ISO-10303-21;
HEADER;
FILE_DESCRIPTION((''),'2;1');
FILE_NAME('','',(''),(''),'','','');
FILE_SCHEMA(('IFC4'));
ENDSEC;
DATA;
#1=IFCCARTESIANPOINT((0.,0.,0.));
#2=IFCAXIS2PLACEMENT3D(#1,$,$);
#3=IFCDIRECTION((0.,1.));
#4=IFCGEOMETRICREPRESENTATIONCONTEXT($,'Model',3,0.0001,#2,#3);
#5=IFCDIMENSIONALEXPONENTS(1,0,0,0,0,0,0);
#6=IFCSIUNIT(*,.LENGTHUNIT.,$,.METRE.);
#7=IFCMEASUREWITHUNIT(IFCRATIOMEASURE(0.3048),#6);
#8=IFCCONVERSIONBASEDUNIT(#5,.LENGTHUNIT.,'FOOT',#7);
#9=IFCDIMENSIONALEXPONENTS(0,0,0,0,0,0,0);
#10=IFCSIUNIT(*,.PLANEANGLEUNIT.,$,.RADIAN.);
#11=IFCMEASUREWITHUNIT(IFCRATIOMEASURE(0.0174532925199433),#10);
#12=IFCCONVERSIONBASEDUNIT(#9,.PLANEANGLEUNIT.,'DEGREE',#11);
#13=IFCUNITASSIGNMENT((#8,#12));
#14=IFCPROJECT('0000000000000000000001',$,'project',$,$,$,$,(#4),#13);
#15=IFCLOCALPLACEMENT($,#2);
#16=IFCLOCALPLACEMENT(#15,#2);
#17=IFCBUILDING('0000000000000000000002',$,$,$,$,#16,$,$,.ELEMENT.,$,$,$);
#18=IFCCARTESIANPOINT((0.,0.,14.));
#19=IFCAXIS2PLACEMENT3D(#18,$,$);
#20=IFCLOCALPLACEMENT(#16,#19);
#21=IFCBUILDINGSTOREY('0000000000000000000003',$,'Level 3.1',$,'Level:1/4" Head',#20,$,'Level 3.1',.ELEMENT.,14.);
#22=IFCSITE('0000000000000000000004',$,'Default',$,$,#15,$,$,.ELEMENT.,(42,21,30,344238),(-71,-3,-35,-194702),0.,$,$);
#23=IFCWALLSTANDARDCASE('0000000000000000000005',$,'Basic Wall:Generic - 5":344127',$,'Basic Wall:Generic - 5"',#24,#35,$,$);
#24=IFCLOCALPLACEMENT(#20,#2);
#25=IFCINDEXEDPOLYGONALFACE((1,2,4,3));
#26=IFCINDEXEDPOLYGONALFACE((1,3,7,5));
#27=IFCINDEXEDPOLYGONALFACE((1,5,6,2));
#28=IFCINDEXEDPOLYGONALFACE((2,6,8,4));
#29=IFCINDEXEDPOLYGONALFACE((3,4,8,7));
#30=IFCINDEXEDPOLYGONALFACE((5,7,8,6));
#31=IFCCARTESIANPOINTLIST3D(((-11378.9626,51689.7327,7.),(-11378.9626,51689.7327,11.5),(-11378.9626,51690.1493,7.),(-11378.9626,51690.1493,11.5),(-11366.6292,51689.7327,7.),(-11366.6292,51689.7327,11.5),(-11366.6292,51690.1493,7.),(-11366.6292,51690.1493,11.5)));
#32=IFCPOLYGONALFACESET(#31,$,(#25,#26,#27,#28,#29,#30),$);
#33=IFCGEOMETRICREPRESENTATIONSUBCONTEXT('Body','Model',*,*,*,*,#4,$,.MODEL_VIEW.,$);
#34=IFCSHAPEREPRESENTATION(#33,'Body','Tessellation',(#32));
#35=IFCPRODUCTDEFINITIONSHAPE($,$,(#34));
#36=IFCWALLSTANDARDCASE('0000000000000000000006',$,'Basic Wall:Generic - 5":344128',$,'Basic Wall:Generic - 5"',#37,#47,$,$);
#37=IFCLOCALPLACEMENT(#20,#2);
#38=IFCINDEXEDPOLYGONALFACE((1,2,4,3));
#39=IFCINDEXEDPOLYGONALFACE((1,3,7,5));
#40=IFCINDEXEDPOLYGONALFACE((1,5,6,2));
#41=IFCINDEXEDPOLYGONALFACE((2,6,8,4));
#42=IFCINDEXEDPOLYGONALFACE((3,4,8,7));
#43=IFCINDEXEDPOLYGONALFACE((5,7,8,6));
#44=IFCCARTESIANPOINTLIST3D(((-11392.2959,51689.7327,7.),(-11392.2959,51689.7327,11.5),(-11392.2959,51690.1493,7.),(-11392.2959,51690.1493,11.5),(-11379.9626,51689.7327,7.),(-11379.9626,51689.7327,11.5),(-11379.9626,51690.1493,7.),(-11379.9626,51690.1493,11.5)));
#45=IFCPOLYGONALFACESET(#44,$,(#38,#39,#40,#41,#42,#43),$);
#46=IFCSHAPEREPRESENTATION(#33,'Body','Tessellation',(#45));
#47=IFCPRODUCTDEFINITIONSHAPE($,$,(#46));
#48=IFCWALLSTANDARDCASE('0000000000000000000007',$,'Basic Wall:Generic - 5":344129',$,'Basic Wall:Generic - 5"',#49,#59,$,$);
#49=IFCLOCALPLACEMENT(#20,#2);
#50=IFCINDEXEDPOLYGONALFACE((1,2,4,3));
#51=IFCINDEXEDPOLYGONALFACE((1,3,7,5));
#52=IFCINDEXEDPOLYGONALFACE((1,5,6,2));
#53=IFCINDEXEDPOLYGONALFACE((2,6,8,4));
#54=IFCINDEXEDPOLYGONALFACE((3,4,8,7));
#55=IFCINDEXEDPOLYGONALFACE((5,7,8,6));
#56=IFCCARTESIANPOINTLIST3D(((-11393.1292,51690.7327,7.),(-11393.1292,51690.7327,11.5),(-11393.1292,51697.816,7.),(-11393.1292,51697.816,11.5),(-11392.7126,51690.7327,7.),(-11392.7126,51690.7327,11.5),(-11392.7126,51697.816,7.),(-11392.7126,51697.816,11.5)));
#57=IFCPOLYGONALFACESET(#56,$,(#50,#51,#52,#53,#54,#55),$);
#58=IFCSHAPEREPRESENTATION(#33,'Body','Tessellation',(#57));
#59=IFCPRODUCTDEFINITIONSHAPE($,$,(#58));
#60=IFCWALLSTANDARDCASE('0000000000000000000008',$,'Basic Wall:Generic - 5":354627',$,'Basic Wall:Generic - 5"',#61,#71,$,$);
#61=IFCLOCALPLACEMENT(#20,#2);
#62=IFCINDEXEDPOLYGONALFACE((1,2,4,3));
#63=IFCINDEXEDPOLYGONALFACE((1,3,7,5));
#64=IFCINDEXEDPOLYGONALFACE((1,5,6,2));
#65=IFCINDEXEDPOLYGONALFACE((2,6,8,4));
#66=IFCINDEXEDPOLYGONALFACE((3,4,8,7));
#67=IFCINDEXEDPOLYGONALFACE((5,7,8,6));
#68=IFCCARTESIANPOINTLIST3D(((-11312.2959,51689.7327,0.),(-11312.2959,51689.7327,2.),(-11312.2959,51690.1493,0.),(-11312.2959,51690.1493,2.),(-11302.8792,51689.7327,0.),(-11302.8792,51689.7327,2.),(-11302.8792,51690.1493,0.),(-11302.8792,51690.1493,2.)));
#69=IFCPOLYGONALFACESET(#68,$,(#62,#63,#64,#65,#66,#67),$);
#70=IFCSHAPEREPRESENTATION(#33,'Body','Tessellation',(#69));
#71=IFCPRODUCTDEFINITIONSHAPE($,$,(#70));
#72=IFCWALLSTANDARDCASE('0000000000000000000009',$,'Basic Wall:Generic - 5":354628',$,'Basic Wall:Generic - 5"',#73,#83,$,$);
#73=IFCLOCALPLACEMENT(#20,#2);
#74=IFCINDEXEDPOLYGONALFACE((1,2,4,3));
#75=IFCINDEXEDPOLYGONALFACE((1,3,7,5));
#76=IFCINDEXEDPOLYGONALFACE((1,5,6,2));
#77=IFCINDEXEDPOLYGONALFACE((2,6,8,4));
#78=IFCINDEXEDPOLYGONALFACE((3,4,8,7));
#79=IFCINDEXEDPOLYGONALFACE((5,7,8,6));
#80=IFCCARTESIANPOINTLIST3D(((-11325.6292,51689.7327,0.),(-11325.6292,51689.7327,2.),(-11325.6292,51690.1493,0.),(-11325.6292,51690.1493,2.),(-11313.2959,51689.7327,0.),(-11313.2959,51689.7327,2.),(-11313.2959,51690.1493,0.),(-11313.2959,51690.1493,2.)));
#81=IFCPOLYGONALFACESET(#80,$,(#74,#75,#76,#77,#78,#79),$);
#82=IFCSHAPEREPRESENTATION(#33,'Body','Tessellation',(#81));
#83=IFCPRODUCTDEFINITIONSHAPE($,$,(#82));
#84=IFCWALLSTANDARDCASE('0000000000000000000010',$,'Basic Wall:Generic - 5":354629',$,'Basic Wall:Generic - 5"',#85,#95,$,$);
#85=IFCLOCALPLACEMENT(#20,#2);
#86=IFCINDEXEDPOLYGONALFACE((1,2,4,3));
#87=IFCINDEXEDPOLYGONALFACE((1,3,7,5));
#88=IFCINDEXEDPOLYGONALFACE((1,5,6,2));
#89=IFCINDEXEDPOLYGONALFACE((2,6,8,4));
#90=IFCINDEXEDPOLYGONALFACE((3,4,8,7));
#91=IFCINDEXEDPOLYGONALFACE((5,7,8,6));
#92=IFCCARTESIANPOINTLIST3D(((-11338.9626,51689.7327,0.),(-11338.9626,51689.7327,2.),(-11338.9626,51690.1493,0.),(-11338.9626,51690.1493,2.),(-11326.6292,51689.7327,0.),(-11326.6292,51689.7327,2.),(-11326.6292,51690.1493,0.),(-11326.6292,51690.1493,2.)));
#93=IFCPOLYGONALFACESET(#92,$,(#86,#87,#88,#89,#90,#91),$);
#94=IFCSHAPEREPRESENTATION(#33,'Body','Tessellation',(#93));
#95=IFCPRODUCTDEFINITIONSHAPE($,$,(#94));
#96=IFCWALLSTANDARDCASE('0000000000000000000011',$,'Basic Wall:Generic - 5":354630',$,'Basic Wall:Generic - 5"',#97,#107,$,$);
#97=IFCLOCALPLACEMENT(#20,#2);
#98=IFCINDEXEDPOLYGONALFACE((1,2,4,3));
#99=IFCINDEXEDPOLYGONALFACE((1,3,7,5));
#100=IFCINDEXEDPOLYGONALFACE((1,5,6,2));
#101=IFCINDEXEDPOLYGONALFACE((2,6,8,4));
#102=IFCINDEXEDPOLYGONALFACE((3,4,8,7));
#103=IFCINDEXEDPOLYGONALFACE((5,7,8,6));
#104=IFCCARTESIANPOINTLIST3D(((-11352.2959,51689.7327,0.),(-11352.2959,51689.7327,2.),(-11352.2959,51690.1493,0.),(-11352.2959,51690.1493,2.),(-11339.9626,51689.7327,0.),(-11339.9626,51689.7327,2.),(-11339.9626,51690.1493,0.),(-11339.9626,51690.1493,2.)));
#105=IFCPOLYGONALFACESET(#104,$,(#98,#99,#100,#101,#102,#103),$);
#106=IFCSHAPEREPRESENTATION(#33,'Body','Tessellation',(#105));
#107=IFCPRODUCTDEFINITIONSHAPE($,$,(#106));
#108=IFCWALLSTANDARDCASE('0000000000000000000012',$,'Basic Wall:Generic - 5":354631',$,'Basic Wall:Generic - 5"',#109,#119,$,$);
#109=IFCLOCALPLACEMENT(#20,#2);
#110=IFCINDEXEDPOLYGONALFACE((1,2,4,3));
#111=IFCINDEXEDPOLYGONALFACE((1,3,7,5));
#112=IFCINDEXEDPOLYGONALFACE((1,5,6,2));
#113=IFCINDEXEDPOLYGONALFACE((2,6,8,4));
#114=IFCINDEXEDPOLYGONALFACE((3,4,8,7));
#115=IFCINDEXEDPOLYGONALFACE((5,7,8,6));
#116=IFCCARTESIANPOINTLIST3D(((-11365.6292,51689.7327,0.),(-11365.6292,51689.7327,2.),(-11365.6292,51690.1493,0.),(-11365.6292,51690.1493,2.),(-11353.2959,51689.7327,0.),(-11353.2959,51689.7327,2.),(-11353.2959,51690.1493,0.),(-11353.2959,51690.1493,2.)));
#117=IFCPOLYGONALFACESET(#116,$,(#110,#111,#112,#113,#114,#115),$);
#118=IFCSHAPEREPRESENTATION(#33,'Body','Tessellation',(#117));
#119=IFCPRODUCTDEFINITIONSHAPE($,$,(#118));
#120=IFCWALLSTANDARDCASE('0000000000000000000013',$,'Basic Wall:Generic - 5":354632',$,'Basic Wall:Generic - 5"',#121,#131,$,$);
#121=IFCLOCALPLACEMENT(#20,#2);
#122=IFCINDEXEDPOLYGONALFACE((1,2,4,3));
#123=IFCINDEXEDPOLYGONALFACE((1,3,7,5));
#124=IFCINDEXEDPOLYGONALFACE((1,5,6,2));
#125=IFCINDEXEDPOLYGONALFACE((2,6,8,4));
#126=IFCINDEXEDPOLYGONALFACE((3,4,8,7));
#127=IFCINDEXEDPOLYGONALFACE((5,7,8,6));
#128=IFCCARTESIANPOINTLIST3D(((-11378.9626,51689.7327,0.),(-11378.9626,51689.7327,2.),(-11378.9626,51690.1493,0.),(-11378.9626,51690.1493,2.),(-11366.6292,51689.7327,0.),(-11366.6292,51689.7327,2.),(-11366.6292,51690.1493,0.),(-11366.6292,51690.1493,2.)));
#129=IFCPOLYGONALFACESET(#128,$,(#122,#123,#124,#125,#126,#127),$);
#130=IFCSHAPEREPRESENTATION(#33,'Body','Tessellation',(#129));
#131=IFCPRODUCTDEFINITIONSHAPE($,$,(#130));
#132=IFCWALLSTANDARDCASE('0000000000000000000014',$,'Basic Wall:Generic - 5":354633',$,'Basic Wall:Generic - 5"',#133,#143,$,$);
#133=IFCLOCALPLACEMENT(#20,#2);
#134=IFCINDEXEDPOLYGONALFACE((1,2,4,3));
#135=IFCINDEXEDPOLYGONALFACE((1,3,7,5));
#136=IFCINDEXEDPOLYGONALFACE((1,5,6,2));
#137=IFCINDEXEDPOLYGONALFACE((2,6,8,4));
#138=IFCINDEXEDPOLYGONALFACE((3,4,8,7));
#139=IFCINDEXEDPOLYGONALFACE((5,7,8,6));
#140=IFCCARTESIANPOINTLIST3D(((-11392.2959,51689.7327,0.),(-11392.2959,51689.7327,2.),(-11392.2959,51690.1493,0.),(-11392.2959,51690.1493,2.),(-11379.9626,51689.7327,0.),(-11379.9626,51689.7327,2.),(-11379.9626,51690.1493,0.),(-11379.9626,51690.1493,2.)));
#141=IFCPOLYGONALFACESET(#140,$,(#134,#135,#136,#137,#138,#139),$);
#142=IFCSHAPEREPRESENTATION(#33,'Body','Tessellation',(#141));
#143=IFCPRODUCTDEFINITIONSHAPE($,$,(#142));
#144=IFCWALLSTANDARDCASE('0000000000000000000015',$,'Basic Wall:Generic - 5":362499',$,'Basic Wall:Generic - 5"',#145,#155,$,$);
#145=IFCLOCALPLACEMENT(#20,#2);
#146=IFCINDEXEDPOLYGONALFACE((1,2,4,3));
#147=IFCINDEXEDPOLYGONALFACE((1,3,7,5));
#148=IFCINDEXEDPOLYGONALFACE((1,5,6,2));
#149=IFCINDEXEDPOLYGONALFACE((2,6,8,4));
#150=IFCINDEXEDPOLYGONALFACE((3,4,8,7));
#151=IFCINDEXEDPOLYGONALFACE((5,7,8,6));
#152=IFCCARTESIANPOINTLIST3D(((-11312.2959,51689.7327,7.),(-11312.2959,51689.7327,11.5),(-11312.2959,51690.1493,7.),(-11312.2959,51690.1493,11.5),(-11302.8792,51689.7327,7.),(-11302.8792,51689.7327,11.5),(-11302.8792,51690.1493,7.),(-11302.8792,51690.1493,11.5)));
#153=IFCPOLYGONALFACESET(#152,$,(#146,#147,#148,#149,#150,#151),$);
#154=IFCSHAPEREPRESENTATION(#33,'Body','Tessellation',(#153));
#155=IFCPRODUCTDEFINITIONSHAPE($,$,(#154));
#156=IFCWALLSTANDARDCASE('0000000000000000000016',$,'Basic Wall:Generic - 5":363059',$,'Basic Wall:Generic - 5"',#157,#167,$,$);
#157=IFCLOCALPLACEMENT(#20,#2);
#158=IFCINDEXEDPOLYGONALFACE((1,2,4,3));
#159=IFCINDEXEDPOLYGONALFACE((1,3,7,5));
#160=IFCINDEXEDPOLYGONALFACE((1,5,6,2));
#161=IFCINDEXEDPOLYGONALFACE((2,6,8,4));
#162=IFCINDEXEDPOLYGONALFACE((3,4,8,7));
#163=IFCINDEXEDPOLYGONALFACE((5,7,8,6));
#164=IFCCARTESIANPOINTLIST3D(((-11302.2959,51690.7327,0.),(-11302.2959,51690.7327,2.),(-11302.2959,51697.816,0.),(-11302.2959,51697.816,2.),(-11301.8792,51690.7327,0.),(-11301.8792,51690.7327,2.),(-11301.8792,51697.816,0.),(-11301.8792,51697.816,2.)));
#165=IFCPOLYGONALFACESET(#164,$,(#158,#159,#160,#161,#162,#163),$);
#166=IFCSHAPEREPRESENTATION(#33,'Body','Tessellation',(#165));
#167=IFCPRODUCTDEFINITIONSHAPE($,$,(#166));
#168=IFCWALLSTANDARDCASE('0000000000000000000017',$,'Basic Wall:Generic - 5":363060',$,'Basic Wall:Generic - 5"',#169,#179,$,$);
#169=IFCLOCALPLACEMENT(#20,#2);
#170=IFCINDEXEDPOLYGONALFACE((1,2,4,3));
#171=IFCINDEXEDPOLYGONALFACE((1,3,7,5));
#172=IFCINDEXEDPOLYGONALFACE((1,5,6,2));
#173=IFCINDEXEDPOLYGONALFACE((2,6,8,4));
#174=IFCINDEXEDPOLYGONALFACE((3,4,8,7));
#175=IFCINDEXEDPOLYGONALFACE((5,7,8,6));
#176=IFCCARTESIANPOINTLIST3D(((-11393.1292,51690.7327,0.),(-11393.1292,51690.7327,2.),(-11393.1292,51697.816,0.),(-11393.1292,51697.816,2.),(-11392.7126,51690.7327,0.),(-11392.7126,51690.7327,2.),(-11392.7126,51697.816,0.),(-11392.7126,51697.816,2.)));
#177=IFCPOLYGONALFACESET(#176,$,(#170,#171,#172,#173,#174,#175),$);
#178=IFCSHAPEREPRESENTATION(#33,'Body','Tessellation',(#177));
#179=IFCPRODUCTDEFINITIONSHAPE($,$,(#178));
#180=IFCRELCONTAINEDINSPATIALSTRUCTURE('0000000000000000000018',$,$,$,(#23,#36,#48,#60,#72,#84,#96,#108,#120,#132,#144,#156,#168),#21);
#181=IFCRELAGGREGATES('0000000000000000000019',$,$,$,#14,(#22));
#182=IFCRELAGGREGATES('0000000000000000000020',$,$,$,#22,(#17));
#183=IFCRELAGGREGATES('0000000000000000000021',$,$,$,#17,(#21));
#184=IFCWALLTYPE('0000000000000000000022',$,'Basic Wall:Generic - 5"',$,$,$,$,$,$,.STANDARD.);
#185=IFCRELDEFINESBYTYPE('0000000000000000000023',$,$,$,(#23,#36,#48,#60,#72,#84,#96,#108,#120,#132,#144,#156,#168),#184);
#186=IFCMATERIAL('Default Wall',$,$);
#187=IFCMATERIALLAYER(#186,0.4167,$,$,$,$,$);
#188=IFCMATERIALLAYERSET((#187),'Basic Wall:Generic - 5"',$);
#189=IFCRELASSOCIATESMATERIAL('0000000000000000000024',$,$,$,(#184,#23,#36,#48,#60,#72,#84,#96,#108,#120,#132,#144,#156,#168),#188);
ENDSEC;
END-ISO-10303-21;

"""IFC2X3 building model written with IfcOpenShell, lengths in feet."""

from ifc_helpers import new_model, entity, si_unit, converted_unit, direction, frame, frame_2d, origin, place, context, subcontext, project, spatial, rectangle, extrude, material, layer, layer_set, layer_usage, type_object, element, save


model = new_model("IFC2X3")

# Units and contexts
model_context = context("Model", 3, precision=0.0001, world=origin(), true_north=direction((0.0, 1.0)))
body_context = subcontext(model_context, "Body", "Model", "MODEL_VIEW")
ifc_project = project(units=[converted_unit("LENGTHUNIT", "FOOT", entity("IfcRatioMeasure", 0.3048), si_unit("LENGTHUNIT", "METRE"), dimensions=[1, 0, 0, 0, 0, 0, 0]), converted_unit("PLANEANGLEUNIT", "DEGREE", entity("IfcRatioMeasure", 0.0174532925199433), si_unit("PLANEANGLEUNIT", "RADIAN"), dimensions=[0, 0, 0, 0, 0, 0, 0])], contexts=[model_context])

# Site, building, storey
site_placement = place(None, origin())
site = spatial("IfcSite", under=ifc_project, at=site_placement, Name="Default", CompositionType="ELEMENT", RefLatitude=(42, 21, 30, 344238), RefLongitude=(-71, -3, -35, -194702), RefElevation=0.0)
building_placement = place(site_placement, origin())
building = spatial("IfcBuilding", under=site, at=building_placement, CompositionType="ELEMENT")
storey_placement = place(building_placement, frame((0.0, 0.0, 14.0)))
storey = spatial("IfcBuildingStorey", under=building, at=storey_placement, Name="Level 3.1", ObjectType="Level:1/4\" Head", LongName="Level 3.1", CompositionType="ELEMENT", Elevation=14.0)

# Shared definitions
ifc_material_1 = material(Name="Default Wall")
ifc_layer = layer(ifc_material_1, 0.4167)
ifc_layer_set = layer_set([ifc_layer], Name="Basic Wall:Generic - 5\"")
wall_type = type_object("IfcWallType", Name="Basic Wall:Generic - 5\"", PredefinedType="STANDARD", material=ifc_layer_set)

# Walls
ifc_layer_usage_1 = layer_usage(ifc_layer_set, "AXIS2", "NEGATIVE", 0.2083)
wall_1_placement = place(storey_placement, frame((-11366.6292, 51689.941, 7.0), z_axis=(0.0, 0.0, 1.0), x_axis=(-1.0, 0.0, 0.0)))
element("IfcWallStandardCase", 1, at=wall_1_placement, inside=storey, type_object=wall_type, material=ifc_layer_usage_1, Name="Basic Wall:Generic - 5\":344127", ObjectType="Basic Wall:Generic - 5\"", context=body_context, shape_type="SweptSolid", body=[
    extrude(rectangle(XDim=12.3333, YDim=0.4167, at=frame_2d((6.1667, 0.0), x_axis=(-1.0, 0.0))), origin(), (0.0, 0.0, 1.0), 4.5),
])
ifc_layer_usage_2 = layer_usage(ifc_layer_set, "AXIS2", "NEGATIVE", 0.2083)
wall_2_placement = place(storey_placement, frame((-11379.9626, 51689.941, 7.0), z_axis=(0.0, 0.0, 1.0), x_axis=(-1.0, 0.0, 0.0)))
element("IfcWallStandardCase", 2, at=wall_2_placement, inside=storey, type_object=wall_type, material=ifc_layer_usage_2, Name="Basic Wall:Generic - 5\":344128", ObjectType="Basic Wall:Generic - 5\"", context=body_context, shape_type="SweptSolid", body=[
    extrude(rectangle(XDim=12.3333, YDim=0.4167, at=frame_2d((6.1667, 0.0), x_axis=(-1.0, 0.0))), origin(), (0.0, 0.0, 1.0), 4.5),
])
ifc_layer_usage_3 = layer_usage(ifc_layer_set, "AXIS2", "POSITIVE", -0.2083)
wall_3_placement = place(storey_placement, frame((-11392.9209, 51697.816, 7.0), z_axis=(0.0, 0.0, 1.0), x_axis=(0.0, -1.0, 0.0)))
element("IfcWallStandardCase", 3, at=wall_3_placement, inside=storey, type_object=wall_type, material=ifc_layer_usage_3, Name="Basic Wall:Generic - 5\":344129", ObjectType="Basic Wall:Generic - 5\"", context=body_context, shape_type="SweptSolid", body=[
    extrude(rectangle(XDim=7.0833, YDim=0.4167, at=frame_2d((3.5417, 0.0), x_axis=(-1.0, 0.0))), origin(), (0.0, 0.0, 1.0), 4.5),
])
ifc_layer_usage_4 = layer_usage(ifc_layer_set, "AXIS2", "NEGATIVE", 0.2083)
wall_4_placement = place(storey_placement, frame((-11302.8792, 51689.941, 0.0), z_axis=(0.0, 0.0, 1.0), x_axis=(-1.0, 0.0, 0.0)))
element("IfcWallStandardCase", 4, at=wall_4_placement, inside=storey, type_object=wall_type, material=ifc_layer_usage_4, Name="Basic Wall:Generic - 5\":354627", ObjectType="Basic Wall:Generic - 5\"", context=body_context, shape_type="SweptSolid", body=[
    extrude(rectangle(XDim=9.4167, YDim=0.4167, at=frame_2d((4.7083, 0.0), x_axis=(-1.0, 0.0))), origin(), (0.0, 0.0, 1.0), 2.0),
])
ifc_layer_usage_5 = layer_usage(ifc_layer_set, "AXIS2", "NEGATIVE", 0.2083)
wall_5_placement = place(storey_placement, frame((-11313.2959, 51689.941, 0.0), z_axis=(0.0, 0.0, 1.0), x_axis=(-1.0, 0.0, 0.0)))
element("IfcWallStandardCase", 5, at=wall_5_placement, inside=storey, type_object=wall_type, material=ifc_layer_usage_5, Name="Basic Wall:Generic - 5\":354628", ObjectType="Basic Wall:Generic - 5\"", context=body_context, shape_type="SweptSolid", body=[
    extrude(rectangle(XDim=12.3333, YDim=0.4167, at=frame_2d((6.1667, 0.0), x_axis=(-1.0, 0.0))), origin(), (0.0, 0.0, 1.0), 2.0),
])
ifc_layer_usage_6 = layer_usage(ifc_layer_set, "AXIS2", "NEGATIVE", 0.2083)
wall_6_placement = place(storey_placement, frame((-11326.6292, 51689.941, 0.0), z_axis=(0.0, 0.0, 1.0), x_axis=(-1.0, 0.0, 0.0)))
element("IfcWallStandardCase", 6, at=wall_6_placement, inside=storey, type_object=wall_type, material=ifc_layer_usage_6, Name="Basic Wall:Generic - 5\":354629", ObjectType="Basic Wall:Generic - 5\"", context=body_context, shape_type="SweptSolid", body=[
    extrude(rectangle(XDim=12.3333, YDim=0.4167, at=frame_2d((6.1667, 0.0), x_axis=(-1.0, 0.0))), origin(), (0.0, 0.0, 1.0), 2.0),
])
ifc_layer_usage_7 = layer_usage(ifc_layer_set, "AXIS2", "NEGATIVE", 0.2083)
wall_7_placement = place(storey_placement, frame((-11339.9626, 51689.941, 0.0), z_axis=(0.0, 0.0, 1.0), x_axis=(-1.0, 0.0, 0.0)))
element("IfcWallStandardCase", 7, at=wall_7_placement, inside=storey, type_object=wall_type, material=ifc_layer_usage_7, Name="Basic Wall:Generic - 5\":354630", ObjectType="Basic Wall:Generic - 5\"", context=body_context, shape_type="SweptSolid", body=[
    extrude(rectangle(XDim=12.3333, YDim=0.4167, at=frame_2d((6.1667, 0.0), x_axis=(-1.0, 0.0))), origin(), (0.0, 0.0, 1.0), 2.0),
])
ifc_layer_usage_8 = layer_usage(ifc_layer_set, "AXIS2", "NEGATIVE", 0.2083)
wall_8_placement = place(storey_placement, frame((-11353.2959, 51689.941, 0.0), z_axis=(0.0, 0.0, 1.0), x_axis=(-1.0, 0.0, 0.0)))
element("IfcWallStandardCase", 8, at=wall_8_placement, inside=storey, type_object=wall_type, material=ifc_layer_usage_8, Name="Basic Wall:Generic - 5\":354631", ObjectType="Basic Wall:Generic - 5\"", context=body_context, shape_type="SweptSolid", body=[
    extrude(rectangle(XDim=12.3333, YDim=0.4167, at=frame_2d((6.1667, 0.0), x_axis=(-1.0, 0.0))), origin(), (0.0, 0.0, 1.0), 2.0),
])
ifc_layer_usage_9 = layer_usage(ifc_layer_set, "AXIS2", "NEGATIVE", 0.2083)
wall_9_placement = place(storey_placement, frame((-11366.6292, 51689.941, 0.0), z_axis=(0.0, 0.0, 1.0), x_axis=(-1.0, 0.0, 0.0)))
element("IfcWallStandardCase", 9, at=wall_9_placement, inside=storey, type_object=wall_type, material=ifc_layer_usage_9, Name="Basic Wall:Generic - 5\":354632", ObjectType="Basic Wall:Generic - 5\"", context=body_context, shape_type="SweptSolid", body=[
    extrude(rectangle(XDim=12.3333, YDim=0.4167, at=frame_2d((6.1667, 0.0), x_axis=(-1.0, 0.0))), origin(), (0.0, 0.0, 1.0), 2.0),
])
ifc_layer_usage_10 = layer_usage(ifc_layer_set, "AXIS2", "NEGATIVE", 0.2083)
wall_10_placement = place(storey_placement, frame((-11379.9626, 51689.941, 0.0), z_axis=(0.0, 0.0, 1.0), x_axis=(-1.0, 0.0, 0.0)))
element("IfcWallStandardCase", 10, at=wall_10_placement, inside=storey, type_object=wall_type, material=ifc_layer_usage_10, Name="Basic Wall:Generic - 5\":354633", ObjectType="Basic Wall:Generic - 5\"", context=body_context, shape_type="SweptSolid", body=[
    extrude(rectangle(XDim=12.3333, YDim=0.4167, at=frame_2d((6.1667, 0.0), x_axis=(-1.0, 0.0))), origin(), (0.0, 0.0, 1.0), 2.0),
])
ifc_layer_usage_11 = layer_usage(ifc_layer_set, "AXIS2", "NEGATIVE", 0.2083)
wall_11_placement = place(storey_placement, frame((-11302.8792, 51689.941, 7.0), z_axis=(0.0, 0.0, 1.0), x_axis=(-1.0, 0.0, 0.0)))
element("IfcWallStandardCase", 11, at=wall_11_placement, inside=storey, type_object=wall_type, material=ifc_layer_usage_11, Name="Basic Wall:Generic - 5\":362499", ObjectType="Basic Wall:Generic - 5\"", context=body_context, shape_type="SweptSolid", body=[
    extrude(rectangle(XDim=9.4167, YDim=0.4167, at=frame_2d((4.7083, 0.0), x_axis=(-1.0, 0.0))), origin(), (0.0, 0.0, 1.0), 4.5),
])
ifc_layer_usage_12 = layer_usage(ifc_layer_set, "AXIS2", "POSITIVE", -0.2083)
wall_12_placement = place(storey_placement, frame((-11302.0876, 51690.7327, 0.0), z_axis=(0.0, 0.0, 1.0), x_axis=(0.0, 1.0, 0.0)))
element("IfcWallStandardCase", 12, at=wall_12_placement, inside=storey, type_object=wall_type, material=ifc_layer_usage_12, Name="Basic Wall:Generic - 5\":363059", ObjectType="Basic Wall:Generic - 5\"", context=body_context, shape_type="SweptSolid", body=[
    extrude(rectangle(XDim=7.0833, YDim=0.4167, at=frame_2d((3.5417, 0.0), x_axis=(-1.0, 0.0))), origin(), (0.0, 0.0, 1.0), 2.0),
])
ifc_layer_usage_13 = layer_usage(ifc_layer_set, "AXIS2", "NEGATIVE", 0.2083)
wall_13_placement = place(storey_placement, frame((-11392.9209, 51690.7327, 0.0), z_axis=(0.0, 0.0, 1.0), x_axis=(0.0, 1.0, 0.0)))
element("IfcWallStandardCase", 13, at=wall_13_placement, inside=storey, type_object=wall_type, material=ifc_layer_usage_13, Name="Basic Wall:Generic - 5\":363060", ObjectType="Basic Wall:Generic - 5\"", context=body_context, shape_type="SweptSolid", body=[
    extrude(rectangle(XDim=7.0833, YDim=0.4167, at=frame_2d((3.5417, 0.0), x_axis=(-1.0, 0.0))), origin(), (0.0, 0.0, 1.0), 2.0),
])

save(model, "model.ifc")
